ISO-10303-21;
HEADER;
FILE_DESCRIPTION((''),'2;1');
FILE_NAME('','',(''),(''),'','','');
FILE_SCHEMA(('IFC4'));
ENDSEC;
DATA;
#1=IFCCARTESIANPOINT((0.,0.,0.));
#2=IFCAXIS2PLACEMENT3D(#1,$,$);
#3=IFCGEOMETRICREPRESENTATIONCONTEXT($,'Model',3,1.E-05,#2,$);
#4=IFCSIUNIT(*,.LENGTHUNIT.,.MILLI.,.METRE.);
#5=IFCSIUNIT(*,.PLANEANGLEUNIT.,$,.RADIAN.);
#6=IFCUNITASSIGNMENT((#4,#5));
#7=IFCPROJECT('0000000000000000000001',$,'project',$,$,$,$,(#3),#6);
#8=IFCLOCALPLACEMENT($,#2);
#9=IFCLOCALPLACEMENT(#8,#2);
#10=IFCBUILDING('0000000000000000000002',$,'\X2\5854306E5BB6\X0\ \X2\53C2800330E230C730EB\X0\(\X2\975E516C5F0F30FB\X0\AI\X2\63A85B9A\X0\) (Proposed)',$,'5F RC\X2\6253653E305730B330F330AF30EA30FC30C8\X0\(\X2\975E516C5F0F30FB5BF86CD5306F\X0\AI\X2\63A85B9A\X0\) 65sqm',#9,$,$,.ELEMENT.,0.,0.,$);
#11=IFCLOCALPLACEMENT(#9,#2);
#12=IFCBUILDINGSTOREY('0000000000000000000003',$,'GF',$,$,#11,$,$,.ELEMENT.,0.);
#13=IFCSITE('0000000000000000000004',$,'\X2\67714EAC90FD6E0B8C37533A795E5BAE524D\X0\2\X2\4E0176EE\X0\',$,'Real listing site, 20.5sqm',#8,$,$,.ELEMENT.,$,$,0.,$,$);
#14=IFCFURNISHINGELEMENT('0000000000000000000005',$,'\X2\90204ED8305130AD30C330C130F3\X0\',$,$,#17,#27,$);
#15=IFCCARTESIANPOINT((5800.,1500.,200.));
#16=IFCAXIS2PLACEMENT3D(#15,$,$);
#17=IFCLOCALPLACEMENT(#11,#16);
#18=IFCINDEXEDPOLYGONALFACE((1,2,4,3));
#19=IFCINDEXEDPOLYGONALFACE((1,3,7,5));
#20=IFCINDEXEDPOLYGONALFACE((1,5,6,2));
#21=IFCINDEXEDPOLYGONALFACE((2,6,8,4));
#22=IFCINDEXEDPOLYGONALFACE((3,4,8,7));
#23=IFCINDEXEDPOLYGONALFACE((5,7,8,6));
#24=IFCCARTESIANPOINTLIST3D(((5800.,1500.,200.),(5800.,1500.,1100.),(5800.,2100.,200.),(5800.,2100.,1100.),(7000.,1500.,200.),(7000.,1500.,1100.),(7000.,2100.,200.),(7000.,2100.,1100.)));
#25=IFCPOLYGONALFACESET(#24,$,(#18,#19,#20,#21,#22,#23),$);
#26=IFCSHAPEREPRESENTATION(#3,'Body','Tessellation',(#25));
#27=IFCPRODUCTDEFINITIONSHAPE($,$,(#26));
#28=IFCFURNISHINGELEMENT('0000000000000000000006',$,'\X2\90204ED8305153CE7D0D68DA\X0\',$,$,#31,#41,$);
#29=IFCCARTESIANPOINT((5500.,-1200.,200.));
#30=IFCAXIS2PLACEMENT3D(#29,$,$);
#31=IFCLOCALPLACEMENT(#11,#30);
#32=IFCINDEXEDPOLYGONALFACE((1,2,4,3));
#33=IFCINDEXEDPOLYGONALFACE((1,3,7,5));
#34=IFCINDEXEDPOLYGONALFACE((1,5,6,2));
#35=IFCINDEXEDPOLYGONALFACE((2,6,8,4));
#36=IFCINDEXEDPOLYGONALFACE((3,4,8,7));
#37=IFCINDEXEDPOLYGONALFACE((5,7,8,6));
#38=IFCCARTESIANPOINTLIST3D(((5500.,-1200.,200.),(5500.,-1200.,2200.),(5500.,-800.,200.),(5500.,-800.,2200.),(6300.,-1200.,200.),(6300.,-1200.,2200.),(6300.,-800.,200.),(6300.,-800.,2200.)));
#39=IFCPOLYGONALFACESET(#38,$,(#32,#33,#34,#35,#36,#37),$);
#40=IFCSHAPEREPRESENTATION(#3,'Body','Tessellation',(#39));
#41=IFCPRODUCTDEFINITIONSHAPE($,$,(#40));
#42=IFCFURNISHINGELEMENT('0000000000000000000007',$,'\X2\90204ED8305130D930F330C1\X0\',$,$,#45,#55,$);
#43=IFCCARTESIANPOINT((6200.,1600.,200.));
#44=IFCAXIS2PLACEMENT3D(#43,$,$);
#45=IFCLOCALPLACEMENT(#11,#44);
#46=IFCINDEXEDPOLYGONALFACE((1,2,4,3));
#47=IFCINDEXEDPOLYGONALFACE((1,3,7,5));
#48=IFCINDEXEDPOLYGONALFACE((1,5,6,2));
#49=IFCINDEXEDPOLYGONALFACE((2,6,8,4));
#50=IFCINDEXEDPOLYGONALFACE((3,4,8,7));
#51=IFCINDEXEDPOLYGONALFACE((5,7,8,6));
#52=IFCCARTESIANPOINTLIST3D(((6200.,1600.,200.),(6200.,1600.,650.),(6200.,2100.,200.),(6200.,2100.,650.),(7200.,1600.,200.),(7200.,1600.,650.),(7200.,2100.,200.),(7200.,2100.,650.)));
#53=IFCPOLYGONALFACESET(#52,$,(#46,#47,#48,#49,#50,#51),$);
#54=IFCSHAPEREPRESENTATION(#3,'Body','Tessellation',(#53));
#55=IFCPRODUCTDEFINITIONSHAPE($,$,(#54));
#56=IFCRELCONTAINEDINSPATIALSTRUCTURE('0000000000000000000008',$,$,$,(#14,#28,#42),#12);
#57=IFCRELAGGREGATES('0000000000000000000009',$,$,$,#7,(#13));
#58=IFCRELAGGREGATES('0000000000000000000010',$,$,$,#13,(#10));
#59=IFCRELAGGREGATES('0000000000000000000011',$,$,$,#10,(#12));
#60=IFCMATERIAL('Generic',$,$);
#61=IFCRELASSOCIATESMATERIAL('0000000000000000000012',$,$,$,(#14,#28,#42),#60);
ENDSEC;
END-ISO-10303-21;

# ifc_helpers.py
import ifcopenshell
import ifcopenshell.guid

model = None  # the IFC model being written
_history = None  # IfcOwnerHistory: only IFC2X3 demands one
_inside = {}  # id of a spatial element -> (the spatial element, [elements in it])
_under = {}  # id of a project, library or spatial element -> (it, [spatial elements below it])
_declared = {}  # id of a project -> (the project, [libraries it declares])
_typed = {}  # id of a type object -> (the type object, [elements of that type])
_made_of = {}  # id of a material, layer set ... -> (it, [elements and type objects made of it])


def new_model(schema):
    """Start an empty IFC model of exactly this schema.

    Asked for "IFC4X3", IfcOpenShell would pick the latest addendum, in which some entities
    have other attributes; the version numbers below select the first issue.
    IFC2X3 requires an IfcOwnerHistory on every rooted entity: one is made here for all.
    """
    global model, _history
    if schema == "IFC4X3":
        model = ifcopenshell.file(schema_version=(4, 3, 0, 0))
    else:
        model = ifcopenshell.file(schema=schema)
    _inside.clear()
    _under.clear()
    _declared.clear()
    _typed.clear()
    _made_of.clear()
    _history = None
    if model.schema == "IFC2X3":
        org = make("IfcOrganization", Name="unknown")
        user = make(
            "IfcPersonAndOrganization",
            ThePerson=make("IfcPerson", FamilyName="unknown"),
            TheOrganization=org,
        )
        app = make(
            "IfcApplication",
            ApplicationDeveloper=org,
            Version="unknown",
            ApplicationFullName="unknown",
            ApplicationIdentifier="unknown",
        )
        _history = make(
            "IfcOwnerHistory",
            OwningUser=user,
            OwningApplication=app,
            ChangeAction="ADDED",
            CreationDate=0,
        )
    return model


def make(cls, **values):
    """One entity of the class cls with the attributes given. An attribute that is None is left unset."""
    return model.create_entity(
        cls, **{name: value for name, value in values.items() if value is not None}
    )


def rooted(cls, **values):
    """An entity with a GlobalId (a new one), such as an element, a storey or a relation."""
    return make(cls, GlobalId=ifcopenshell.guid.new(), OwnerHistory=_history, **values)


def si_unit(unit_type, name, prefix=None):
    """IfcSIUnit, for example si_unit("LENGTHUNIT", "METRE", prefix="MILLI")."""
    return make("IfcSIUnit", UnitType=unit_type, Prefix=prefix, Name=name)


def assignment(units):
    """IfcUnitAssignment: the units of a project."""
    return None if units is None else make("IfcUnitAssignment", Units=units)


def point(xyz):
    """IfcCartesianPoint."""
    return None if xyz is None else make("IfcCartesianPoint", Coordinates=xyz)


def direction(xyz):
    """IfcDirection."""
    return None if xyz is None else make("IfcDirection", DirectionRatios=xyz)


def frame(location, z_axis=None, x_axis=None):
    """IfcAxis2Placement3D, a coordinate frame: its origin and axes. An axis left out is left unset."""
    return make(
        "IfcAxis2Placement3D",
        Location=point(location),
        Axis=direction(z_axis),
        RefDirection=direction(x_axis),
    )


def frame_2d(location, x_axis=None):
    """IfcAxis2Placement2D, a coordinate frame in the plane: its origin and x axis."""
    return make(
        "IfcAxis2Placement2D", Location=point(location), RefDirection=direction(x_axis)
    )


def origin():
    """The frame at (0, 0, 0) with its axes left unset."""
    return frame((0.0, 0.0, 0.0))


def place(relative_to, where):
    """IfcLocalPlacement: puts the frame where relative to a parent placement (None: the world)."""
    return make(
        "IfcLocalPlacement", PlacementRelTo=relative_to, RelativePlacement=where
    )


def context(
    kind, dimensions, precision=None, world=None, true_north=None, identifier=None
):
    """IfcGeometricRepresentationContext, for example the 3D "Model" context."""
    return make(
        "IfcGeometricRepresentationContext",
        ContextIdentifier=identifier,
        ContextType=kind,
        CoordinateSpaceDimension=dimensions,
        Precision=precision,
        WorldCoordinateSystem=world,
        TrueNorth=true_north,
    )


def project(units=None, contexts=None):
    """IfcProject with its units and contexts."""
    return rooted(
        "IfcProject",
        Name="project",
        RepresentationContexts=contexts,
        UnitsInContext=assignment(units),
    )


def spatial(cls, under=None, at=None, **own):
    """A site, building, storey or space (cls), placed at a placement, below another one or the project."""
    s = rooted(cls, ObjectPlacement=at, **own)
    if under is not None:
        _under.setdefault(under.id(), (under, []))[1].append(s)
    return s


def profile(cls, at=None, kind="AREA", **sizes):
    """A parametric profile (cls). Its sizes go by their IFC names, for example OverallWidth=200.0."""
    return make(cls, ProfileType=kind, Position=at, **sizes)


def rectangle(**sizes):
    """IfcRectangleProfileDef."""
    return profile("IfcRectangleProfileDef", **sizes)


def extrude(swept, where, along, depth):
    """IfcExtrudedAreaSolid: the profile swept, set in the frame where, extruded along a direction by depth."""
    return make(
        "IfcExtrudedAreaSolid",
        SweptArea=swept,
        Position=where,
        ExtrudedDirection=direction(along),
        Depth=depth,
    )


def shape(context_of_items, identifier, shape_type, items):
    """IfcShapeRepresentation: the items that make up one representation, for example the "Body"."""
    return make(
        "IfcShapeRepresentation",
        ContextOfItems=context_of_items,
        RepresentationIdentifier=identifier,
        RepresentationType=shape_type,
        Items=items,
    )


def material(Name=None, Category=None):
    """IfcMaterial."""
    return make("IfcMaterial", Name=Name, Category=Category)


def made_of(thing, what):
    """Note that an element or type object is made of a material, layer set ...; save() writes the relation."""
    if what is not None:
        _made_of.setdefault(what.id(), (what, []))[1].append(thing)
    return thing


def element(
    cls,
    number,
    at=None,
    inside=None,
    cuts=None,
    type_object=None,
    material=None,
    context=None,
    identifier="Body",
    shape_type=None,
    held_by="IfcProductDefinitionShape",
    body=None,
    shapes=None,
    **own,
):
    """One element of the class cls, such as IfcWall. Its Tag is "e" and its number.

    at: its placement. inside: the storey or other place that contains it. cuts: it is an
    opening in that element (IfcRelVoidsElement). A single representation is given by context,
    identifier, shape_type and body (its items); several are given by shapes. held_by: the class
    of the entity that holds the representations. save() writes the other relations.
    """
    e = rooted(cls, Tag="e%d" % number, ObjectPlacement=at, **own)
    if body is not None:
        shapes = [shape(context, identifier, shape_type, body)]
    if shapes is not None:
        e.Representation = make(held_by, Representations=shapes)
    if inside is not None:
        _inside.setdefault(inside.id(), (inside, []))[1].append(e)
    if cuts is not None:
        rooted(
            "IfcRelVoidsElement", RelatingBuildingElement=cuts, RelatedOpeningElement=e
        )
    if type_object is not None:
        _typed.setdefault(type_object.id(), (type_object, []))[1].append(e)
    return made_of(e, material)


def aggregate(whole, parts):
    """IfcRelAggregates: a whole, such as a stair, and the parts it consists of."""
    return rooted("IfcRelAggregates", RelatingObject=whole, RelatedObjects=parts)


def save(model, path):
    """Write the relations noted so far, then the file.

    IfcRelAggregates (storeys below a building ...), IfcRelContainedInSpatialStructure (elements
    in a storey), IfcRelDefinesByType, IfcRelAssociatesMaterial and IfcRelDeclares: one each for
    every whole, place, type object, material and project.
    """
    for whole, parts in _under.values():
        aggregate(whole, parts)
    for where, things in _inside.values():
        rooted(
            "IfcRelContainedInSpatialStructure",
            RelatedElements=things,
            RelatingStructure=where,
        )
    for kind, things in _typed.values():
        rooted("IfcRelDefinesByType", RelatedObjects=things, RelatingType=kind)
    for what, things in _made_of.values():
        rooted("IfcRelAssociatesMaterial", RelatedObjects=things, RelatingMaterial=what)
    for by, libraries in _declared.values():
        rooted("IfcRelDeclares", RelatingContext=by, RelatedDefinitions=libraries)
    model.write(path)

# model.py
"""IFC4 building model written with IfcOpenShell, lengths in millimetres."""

from ifc_helpers import new_model, si_unit, frame, frame_2d, origin, place, context, project, spatial, rectangle, extrude, material, element, save


model = new_model("IFC4")

# Units and contexts
model_context = context("Model", 3, precision=1e-05, world=origin())
ifc_project = project(units=[si_unit("LENGTHUNIT", "METRE", prefix="MILLI"), si_unit("PLANEANGLEUNIT", "RADIAN")], contexts=[model_context])

# Site, building, storey
site_placement = place(None, origin())
site = spatial("IfcSite", under=ifc_project, at=site_placement, Name="東京都渋谷区神宮前2丁目", ObjectType="Real listing site, 20.5sqm", CompositionType="ELEMENT", RefElevation=0.0)
building_placement = place(site_placement, origin())
building = spatial("IfcBuilding", under=site, at=building_placement, Name="塔の家 参考モデル(非公式・AI推定) (Proposed)", ObjectType="5F RC打放しコンクリート(非公式・寸法はAI推定) 65sqm", CompositionType="ELEMENT", ElevationOfRefHeight=0.0, ElevationOfTerrain=0.0)
storey_placement = place(building_placement, origin())
storey = spatial("IfcBuildingStorey", under=building, at=storey_placement, Name="GF", CompositionType="ELEMENT", Elevation=0.0)

# Shared definitions
ifc_material = material(Name="Generic")

# Furnishing elements
furnishing_1_placement = place(storey_placement, frame((5800.0, 1500.0, 200.0)))
element("IfcFurnishingElement", 1, at=furnishing_1_placement, inside=storey, material=ifc_material, Name="造付けキッチン", context=model_context, shape_type="SweptSolid", body=[
    extrude(rectangle(XDim=1200.0, YDim=600.0, at=frame_2d((600.0, 300.0))), frame((5800.0, 1500.0, 200.0)), (0.0, 0.0, 1.0), 900.0),
])
furnishing_2_placement = place(storey_placement, frame((5500.0, -1200.0, 200.0)))
element("IfcFurnishingElement", 2, at=furnishing_2_placement, inside=storey, material=ifc_material, Name="造付け収納棚", context=model_context, shape_type="SweptSolid", body=[
    extrude(rectangle(XDim=800.0, YDim=400.0, at=frame_2d((400.0, 200.0))), frame((5500.0, -1200.0, 200.0)), (0.0, 0.0, 1.0), 2000.0),
])
furnishing_3_placement = place(storey_placement, frame((6200.0, 1600.0, 200.0)))
element("IfcFurnishingElement", 3, at=furnishing_3_placement, inside=storey, material=ifc_material, Name="造付けベンチ", context=model_context, shape_type="SweptSolid", body=[
    extrude(rectangle(XDim=1000.0, YDim=500.0, at=frame_2d((500.0, 250.0))), frame((6200.0, 1600.0, 200.0)), (0.0, 0.0, 1.0), 450.0),
])

save(model, "model.ifc")
